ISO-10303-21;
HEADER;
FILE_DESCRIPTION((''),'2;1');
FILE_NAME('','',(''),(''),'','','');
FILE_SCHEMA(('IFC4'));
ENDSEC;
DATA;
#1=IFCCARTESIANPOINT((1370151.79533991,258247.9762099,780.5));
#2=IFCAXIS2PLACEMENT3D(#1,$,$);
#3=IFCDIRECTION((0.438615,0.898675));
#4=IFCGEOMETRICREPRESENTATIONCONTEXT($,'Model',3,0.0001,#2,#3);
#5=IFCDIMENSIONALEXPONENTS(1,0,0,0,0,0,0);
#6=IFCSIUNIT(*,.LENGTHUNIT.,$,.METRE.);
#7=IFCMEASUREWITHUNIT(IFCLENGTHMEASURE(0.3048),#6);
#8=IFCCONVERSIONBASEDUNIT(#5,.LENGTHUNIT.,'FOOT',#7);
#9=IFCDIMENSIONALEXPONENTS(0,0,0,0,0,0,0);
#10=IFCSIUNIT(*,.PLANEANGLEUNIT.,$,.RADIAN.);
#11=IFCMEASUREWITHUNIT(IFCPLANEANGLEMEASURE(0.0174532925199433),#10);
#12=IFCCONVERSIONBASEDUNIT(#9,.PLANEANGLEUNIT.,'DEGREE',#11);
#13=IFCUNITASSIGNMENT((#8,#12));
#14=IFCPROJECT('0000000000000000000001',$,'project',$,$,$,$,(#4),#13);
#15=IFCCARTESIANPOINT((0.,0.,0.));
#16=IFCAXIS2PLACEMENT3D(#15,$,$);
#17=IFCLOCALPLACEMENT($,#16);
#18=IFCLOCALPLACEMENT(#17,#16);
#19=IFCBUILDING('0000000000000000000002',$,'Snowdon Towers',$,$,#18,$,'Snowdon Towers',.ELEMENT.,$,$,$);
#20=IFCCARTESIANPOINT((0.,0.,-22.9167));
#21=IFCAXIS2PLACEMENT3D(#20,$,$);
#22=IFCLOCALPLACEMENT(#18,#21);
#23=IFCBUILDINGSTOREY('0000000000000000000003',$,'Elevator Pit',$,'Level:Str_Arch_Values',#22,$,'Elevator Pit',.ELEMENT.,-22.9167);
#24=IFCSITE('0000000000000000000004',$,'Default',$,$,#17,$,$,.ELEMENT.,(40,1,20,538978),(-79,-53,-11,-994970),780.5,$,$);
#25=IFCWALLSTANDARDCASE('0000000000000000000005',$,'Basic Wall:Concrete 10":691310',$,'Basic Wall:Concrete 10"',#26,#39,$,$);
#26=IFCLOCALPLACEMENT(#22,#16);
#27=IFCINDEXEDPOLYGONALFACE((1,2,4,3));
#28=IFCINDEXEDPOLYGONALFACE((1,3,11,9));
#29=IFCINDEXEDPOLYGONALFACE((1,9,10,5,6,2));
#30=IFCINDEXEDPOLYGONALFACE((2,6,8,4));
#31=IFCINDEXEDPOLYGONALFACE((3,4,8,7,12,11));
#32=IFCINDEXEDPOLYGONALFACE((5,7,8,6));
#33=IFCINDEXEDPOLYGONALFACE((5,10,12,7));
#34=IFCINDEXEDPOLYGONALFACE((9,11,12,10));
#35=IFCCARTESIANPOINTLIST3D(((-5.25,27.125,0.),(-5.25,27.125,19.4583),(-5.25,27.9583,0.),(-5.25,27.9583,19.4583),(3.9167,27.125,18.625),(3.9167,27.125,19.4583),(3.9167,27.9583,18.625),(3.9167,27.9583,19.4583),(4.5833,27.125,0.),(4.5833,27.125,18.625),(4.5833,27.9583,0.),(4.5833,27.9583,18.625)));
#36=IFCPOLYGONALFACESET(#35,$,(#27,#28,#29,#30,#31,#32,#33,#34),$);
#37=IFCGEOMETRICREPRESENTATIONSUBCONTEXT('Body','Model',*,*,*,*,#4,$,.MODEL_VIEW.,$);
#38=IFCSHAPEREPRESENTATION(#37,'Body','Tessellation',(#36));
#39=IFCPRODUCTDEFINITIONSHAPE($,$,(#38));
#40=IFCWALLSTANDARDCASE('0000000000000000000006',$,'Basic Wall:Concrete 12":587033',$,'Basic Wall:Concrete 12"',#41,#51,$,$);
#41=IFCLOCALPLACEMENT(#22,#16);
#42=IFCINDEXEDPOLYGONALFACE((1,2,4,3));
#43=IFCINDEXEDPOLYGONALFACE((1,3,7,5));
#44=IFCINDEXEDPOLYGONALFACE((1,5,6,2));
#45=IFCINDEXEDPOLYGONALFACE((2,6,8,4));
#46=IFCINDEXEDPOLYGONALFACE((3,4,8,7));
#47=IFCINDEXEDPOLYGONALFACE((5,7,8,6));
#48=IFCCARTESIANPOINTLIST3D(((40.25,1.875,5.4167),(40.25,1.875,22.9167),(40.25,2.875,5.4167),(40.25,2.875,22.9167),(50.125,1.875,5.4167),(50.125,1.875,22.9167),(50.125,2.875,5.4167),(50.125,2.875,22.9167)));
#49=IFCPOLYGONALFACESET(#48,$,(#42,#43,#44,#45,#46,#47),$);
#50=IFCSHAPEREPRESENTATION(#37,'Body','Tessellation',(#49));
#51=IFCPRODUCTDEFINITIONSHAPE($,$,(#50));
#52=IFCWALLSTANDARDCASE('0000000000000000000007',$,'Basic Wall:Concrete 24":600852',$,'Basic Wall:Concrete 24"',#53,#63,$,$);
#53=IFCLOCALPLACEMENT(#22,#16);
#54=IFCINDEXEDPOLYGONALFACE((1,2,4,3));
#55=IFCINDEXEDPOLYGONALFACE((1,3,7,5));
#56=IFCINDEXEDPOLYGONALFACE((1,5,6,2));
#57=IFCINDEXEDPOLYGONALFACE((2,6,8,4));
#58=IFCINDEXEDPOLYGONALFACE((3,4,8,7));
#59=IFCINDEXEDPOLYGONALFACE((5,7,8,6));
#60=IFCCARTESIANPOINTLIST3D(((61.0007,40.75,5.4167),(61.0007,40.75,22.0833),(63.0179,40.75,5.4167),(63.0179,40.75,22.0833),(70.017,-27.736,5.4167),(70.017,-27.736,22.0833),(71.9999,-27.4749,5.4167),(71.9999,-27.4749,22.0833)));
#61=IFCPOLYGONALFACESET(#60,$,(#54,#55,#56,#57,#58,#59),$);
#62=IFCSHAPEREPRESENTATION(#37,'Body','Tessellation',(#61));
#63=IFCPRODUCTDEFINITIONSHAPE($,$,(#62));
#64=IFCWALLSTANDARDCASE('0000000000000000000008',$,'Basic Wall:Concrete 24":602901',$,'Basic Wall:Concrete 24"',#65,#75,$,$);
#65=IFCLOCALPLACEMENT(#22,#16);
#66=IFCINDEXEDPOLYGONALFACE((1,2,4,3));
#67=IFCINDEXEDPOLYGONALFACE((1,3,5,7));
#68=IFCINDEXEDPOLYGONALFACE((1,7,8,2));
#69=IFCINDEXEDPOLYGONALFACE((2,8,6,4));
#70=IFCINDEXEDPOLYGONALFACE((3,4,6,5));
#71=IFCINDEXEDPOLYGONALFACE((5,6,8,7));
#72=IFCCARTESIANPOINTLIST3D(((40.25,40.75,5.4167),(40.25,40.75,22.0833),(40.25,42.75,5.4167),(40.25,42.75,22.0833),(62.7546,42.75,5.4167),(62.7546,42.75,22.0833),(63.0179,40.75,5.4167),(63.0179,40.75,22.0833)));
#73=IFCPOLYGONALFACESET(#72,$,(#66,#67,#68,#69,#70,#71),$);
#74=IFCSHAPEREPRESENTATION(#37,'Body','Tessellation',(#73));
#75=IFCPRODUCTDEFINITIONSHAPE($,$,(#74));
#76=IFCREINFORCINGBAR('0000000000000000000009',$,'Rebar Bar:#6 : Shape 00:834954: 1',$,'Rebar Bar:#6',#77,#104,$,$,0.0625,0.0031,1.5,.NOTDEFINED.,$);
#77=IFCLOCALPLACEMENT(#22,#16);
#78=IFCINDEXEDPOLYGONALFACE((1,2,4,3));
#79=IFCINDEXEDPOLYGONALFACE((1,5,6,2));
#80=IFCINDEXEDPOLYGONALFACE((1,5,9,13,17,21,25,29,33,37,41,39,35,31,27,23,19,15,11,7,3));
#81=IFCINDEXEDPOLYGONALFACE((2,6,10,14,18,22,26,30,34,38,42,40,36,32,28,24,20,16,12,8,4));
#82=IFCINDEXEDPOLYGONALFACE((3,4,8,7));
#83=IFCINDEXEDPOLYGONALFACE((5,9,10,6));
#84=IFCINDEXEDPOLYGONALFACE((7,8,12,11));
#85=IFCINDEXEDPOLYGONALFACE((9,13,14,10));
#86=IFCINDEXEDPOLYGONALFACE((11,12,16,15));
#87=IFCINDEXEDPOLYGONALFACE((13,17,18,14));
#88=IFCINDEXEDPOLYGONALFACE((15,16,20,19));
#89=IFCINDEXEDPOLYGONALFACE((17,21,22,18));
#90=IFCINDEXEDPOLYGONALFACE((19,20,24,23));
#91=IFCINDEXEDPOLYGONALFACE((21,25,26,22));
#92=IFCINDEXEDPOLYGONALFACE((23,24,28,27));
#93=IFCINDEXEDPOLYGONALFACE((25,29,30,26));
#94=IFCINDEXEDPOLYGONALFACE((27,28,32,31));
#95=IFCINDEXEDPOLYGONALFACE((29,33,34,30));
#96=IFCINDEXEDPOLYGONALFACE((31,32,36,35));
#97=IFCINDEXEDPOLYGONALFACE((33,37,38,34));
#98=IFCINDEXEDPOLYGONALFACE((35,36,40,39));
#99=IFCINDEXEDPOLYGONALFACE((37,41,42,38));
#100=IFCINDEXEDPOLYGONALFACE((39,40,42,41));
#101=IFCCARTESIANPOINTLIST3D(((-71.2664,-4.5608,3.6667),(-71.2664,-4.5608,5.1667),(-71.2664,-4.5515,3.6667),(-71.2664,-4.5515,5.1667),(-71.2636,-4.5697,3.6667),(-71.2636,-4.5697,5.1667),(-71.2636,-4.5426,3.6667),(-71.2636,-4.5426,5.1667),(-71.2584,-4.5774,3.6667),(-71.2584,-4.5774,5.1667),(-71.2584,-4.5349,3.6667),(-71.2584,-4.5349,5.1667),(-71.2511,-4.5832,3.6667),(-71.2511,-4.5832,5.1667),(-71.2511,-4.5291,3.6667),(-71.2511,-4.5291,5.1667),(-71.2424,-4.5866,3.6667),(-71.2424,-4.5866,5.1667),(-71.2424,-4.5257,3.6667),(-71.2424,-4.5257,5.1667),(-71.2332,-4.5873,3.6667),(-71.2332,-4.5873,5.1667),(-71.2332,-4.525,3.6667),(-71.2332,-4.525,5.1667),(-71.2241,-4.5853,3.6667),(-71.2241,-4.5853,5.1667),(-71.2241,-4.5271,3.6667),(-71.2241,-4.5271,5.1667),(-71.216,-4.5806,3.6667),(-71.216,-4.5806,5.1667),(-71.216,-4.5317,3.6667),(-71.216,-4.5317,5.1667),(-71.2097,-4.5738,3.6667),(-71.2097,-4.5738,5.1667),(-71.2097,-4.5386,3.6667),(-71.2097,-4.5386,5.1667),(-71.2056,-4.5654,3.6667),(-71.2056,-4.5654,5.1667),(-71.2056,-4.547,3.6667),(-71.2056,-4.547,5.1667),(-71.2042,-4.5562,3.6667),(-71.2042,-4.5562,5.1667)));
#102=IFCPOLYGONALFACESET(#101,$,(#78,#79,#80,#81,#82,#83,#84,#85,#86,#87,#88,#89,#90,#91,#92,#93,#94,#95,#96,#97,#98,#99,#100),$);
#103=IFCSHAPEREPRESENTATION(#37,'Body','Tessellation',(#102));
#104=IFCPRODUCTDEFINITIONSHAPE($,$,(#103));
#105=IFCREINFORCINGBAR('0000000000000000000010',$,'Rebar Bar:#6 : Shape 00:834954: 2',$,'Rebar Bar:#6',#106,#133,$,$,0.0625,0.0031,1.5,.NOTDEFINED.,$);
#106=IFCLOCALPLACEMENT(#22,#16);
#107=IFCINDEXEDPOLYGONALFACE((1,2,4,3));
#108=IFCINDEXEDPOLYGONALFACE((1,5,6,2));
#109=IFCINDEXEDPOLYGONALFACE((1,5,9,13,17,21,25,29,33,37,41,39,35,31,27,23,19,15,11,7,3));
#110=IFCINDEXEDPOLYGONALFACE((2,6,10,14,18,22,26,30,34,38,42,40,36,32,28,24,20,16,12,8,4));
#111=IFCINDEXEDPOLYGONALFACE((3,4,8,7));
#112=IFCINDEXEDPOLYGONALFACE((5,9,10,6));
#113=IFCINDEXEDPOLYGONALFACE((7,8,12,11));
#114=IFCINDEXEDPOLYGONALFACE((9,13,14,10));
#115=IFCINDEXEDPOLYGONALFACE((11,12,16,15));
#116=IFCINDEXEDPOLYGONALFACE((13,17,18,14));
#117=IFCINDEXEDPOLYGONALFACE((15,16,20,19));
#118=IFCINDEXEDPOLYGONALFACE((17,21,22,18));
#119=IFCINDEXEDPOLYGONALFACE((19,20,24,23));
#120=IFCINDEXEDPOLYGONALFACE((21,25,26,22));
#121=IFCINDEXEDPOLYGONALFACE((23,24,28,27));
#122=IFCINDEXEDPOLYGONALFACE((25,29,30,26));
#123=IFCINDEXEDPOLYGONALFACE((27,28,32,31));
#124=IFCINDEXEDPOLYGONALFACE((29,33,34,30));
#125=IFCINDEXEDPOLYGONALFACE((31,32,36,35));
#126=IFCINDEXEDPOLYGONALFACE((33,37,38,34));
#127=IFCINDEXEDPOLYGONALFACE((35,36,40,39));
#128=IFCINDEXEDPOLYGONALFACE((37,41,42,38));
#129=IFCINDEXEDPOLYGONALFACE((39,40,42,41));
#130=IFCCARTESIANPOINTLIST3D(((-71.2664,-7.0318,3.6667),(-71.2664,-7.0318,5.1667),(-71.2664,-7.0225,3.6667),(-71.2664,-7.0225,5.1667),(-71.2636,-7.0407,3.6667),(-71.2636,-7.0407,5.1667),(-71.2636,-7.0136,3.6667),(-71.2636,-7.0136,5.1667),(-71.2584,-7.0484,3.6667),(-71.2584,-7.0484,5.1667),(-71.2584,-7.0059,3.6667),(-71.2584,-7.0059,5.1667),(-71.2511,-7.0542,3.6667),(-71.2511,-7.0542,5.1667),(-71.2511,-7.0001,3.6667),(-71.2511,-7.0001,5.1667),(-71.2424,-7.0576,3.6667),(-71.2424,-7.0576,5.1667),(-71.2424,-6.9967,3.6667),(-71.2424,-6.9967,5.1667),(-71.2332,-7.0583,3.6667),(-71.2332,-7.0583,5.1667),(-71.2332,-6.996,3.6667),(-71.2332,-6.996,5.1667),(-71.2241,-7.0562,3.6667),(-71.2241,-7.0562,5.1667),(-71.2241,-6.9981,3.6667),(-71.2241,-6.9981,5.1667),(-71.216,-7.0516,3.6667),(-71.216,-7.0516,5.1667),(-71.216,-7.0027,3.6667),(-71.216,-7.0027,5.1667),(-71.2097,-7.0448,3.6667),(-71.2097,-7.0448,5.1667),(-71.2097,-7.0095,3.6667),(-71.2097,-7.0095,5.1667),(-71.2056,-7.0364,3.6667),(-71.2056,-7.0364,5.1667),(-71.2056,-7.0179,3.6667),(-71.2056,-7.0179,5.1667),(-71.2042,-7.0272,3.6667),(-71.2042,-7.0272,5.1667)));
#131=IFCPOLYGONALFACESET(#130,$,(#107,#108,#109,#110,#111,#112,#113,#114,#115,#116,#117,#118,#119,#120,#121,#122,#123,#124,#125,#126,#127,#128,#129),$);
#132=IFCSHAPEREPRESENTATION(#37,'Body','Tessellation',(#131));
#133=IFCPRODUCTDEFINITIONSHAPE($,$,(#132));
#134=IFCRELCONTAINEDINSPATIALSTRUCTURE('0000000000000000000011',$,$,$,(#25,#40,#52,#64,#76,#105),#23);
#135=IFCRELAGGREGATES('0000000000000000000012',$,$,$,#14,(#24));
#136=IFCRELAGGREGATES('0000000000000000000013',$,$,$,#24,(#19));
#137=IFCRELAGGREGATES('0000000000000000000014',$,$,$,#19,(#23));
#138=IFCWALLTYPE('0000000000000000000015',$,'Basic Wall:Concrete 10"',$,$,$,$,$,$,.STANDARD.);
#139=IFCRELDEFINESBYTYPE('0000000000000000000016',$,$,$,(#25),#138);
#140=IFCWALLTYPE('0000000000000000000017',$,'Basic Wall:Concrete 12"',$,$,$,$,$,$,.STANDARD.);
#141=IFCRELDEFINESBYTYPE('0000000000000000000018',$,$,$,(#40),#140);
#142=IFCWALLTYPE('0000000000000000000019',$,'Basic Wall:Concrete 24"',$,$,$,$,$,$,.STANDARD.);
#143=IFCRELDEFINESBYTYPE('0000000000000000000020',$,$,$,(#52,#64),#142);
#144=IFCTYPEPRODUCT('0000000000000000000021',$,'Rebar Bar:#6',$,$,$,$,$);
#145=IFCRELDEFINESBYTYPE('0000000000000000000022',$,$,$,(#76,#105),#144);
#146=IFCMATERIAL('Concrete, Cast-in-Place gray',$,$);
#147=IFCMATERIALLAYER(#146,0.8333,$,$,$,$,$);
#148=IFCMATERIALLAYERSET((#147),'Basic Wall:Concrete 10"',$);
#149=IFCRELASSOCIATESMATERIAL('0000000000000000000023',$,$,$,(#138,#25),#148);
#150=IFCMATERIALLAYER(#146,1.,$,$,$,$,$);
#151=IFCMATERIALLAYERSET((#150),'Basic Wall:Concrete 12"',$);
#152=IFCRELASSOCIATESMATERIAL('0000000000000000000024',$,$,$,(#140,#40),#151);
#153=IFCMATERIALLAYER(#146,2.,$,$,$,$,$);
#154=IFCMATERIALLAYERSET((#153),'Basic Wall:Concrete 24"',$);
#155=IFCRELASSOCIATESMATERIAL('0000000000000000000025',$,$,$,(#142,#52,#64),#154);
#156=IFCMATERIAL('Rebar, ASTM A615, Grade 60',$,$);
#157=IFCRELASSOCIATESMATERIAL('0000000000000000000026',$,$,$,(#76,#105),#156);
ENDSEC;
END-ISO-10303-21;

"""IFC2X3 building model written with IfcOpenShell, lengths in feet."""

from ifc_helpers import new_model, entity, si_unit, converted_unit, direction, frame, frame_2d, origin, place, context, subcontext, project, spatial, polyline, rectangle, outline, extrude, clip, bounded_halfspace, material, layer, layer_set, layer_usage, type_object, element, save


model = new_model("IFC2X3")

# Units and contexts
model_context = context("Model", 3, precision=0.0001, world=frame((1370151.79533991, 258247.9762099, 780.5)), true_north=direction((0.438615, 0.898675)))
body_context = subcontext(model_context, "Body", "Model", "MODEL_VIEW")
ifc_project = project(units=[converted_unit("LENGTHUNIT", "FOOT", entity("IfcLengthMeasure", 0.3048), si_unit("LENGTHUNIT", "METRE"), dimensions=[1, 0, 0, 0, 0, 0, 0]), converted_unit("PLANEANGLEUNIT", "DEGREE", entity("IfcPlaneAngleMeasure", 0.0174532925199433), si_unit("PLANEANGLEUNIT", "RADIAN"), dimensions=[0, 0, 0, 0, 0, 0, 0])], contexts=[model_context])

# Site, building, storey
site_placement = place(None, origin())
site = spatial("IfcSite", under=ifc_project, at=site_placement, Name="Default", CompositionType="ELEMENT", RefLatitude=(40, 1, 20, 538978), RefLongitude=(-79, -53, -11, -994970), RefElevation=780.5)
building_placement = place(site_placement, origin())
building = spatial("IfcBuilding", under=site, at=building_placement, Name="Snowdon Towers", LongName="Snowdon Towers", CompositionType="ELEMENT")
storey_placement = place(building_placement, frame((0.0, 0.0, -22.9167)))
storey = spatial("IfcBuildingStorey", under=building, at=storey_placement, Name="Elevator Pit", ObjectType="Level:Str_Arch_Values", LongName="Elevator Pit", CompositionType="ELEMENT", Elevation=-22.9167)

# Walls
ifc_material_1 = material(Name="Concrete, Cast-in-Place gray")
ifc_layer_1 = layer(ifc_material_1, 0.8333)
ifc_layer_set_1 = layer_set([ifc_layer_1], Name="Basic Wall:Concrete 10\"")
ifc_layer_usage_1 = layer_usage(ifc_layer_set_1, "AXIS2", "NEGATIVE", 0.4167)
wall_type_1 = type_object("IfcWallType", Name="Basic Wall:Concrete 10\"", PredefinedType="STANDARD", material=ifc_layer_set_1)
wall_1_placement = place(storey_placement, frame((4.5833, 27.5417, 0.0), z_axis=(0.0, 0.0, 1.0), x_axis=(-1.0, 0.0, 0.0)))
element("IfcWallStandardCase", 1, at=wall_1_placement, inside=storey, type_object=wall_type_1, material=ifc_layer_usage_1, Name="Basic Wall:Concrete 10\":691310", ObjectType="Basic Wall:Concrete 10\"", context=body_context, shape_type="Clipping", body=[
    clip(clip(extrude(rectangle(XDim=9.8333, YDim=0.8333, at=frame_2d((4.9167, 0.0), x_axis=(-1.0, 0.0))), origin(), (0.0, 0.0, 1.0), 19.4583), bounded_halfspace(frame((0.6667, -0.4167, 18.625), z_axis=(0.0, 0.0, -1.0), x_axis=(1.0, 0.0, 0.0)), True, frame((0.6667, -0.4167, 18.625), z_axis=(0.0, 0.0, -1.0), x_axis=(1.0, 0.0, 0.0)), polyline([(0.0, 0.0), (-0.6667, 0.0), (-0.6667, -0.8333), (0.0, -0.8333), (0.0, 0.0)]))), bounded_halfspace(frame((0.6667, 0.4167, 18.625), z_axis=(1.0, 0.0, 0.0), x_axis=(0.0, 0.0, 1.0)), True, frame((0.6667, 0.4167, 18.625), z_axis=(1.0, 0.0, 0.0), x_axis=(0.0, 0.0, 1.0)), polyline([(0.0, 0.0), (0.8333, 0.0), (0.8333, 0.8333), (0.0, 0.8333), (0.0, 0.0)]))),
])
ifc_layer_2 = layer(ifc_material_1, 1.0)
ifc_layer_set_2 = layer_set([ifc_layer_2], Name="Basic Wall:Concrete 12\"")
ifc_layer_usage_2 = layer_usage(ifc_layer_set_2, "AXIS2", "NEGATIVE", 0.5)
wall_type_2 = type_object("IfcWallType", Name="Basic Wall:Concrete 12\"", PredefinedType="STANDARD", material=ifc_layer_set_2)
wall_2_placement = place(storey_placement, frame((50.125, 2.375, 5.4167), z_axis=(0.0, 0.0, 1.0), x_axis=(-1.0, 0.0, 0.0)))
element("IfcWallStandardCase", 2, at=wall_2_placement, inside=storey, type_object=wall_type_2, material=ifc_layer_usage_2, Name="Basic Wall:Concrete 12\":587033", ObjectType="Basic Wall:Concrete 12\"", context=body_context, shape_type="SweptSolid", body=[
    extrude(rectangle(XDim=9.875, YDim=1.0, at=frame_2d((4.9375, 0.0), x_axis=(-1.0, 0.0))), origin(), (0.0, 0.0, 1.0), 17.5),
])
ifc_layer_3 = layer(ifc_material_1, 2.0)
ifc_layer_set_3 = layer_set([ifc_layer_3], Name="Basic Wall:Concrete 24\"")
ifc_layer_usage_3 = layer_usage(ifc_layer_set_3, "AXIS2", "NEGATIVE", 1.0)
wall_type_3 = type_object("IfcWallType", Name="Basic Wall:Concrete 24\"", PredefinedType="STANDARD", material=ifc_layer_set_3)
wall_3_placement = place(storey_placement, frame((61.9921, 40.8805, 5.4167), z_axis=(0.0, 0.0, 1.0), x_axis=(0.130526, -0.991445, 0.0)))
element("IfcWallStandardCase", 3, at=wall_3_placement, inside=storey, type_object=wall_type_3, material=ifc_layer_usage_3, Name="Basic Wall:Concrete 24\":600852", ObjectType="Basic Wall:Concrete 24\"", context=body_context, shape_type="Clipping", body=[
    clip(extrude(outline(polyline([(69.0769, -1.0), (69.0769, 1.0), (0.2633, 1.0), (0.0, -1.0), (67.0769, -1.0), (69.0769, -1.0)])), origin(), (0.0, 0.0, 1.0), 16.6667), bounded_halfspace(frame((0.0, -1.0, 16.6667), z_axis=(0.0, 0.0, -1.0), x_axis=(-0.130526, -0.991445, 0.0)), True, frame((0.0, -1.0, 16.6667), z_axis=(0.0, 0.0, -1.0), x_axis=(-0.130526, -0.991445, 0.0)), polyline([(0.0, 0.0), (-2.0173, 0.0), (-10.9992, -68.2249), (-9.0163, -68.486), (-8.7553, -66.5031), (0.0, 0.0)]))),
])
ifc_layer_usage_4 = layer_usage(ifc_layer_set_3, "AXIS2", "NEGATIVE", 1.0)
wall_4_placement = place(storey_placement, frame((40.25, 41.75, 5.4167)))
element("IfcWallStandardCase", 4, at=wall_4_placement, inside=storey, type_object=wall_type_3, material=ifc_layer_usage_4, Name="Basic Wall:Concrete 24\":602901", ObjectType="Basic Wall:Concrete 24\"", context=body_context, shape_type="Clipping", body=[
    clip(extrude(outline(polyline([(22.7679, -1.0), (22.5046, 1.0), (0.0, 1.0), (0.0, -1.0), (20.7507, -1.0), (22.7679, -1.0)])), origin(), (0.0, 0.0, 1.0), 16.6667), bounded_halfspace(frame((0.0, -1.0, 16.6667), z_axis=(0.0, 0.0, -1.0), x_axis=(-1.0, 0.0, 0.0)), True, frame((0.0, -1.0, 16.6667), z_axis=(0.0, 0.0, -1.0), x_axis=(-1.0, 0.0, 0.0)), polyline([(0.0, 0.0), (0.0, 2.0), (-22.5046, 2.0), (-22.7679, 0.0), (-20.7507, 0.0), (-2.0, 0.0), (0.0, 0.0)]))),
])

# Reinforcing bars
ifc_material_2 = material(Name="Rebar, ASTM A615, Grade 60")
type_product = type_object("IfcTypeProduct", Name="Rebar Bar:#6")
reinforcing_bar_1_placement = place(storey_placement, origin())
element("IfcReinforcingBar", 5, at=reinforcing_bar_1_placement, inside=storey, type_object=type_product, material=ifc_material_2, Name="Rebar Bar:#6 : Shape 00:834954: 1", ObjectType="Rebar Bar:#6", BarLength=1.5, BarRole="NOTDEFINED", CrossSectionArea=0.0031, NominalDiameter=0.0625, context=body_context, shape_type="AdvancedSweptSolid", body=[
    entity("IfcSweptDiskSolid", entity("IfcCompositeCurve", [entity("IfcCompositeCurveSegment", "CONTINUOUS", True, entity("IfcPolyline", [entity("IfcCartesianPoint", [-71.2355, -4.5562, 3.6667]), entity("IfcCartesianPoint", [-71.2355, -4.5562, 5.1667])]))], False), 0.0312, None, 0.0, 1.0),
])
reinforcing_bar_2_placement = place(storey_placement, origin())
element("IfcReinforcingBar", 6, at=reinforcing_bar_2_placement, inside=storey, type_object=type_product, material=ifc_material_2, Name="Rebar Bar:#6 : Shape 00:834954: 2", ObjectType="Rebar Bar:#6", BarLength=1.5, BarRole="NOTDEFINED", CrossSectionArea=0.0031, NominalDiameter=0.0625, context=body_context, shape_type="AdvancedSweptSolid", body=[
    entity("IfcSweptDiskSolid", entity("IfcCompositeCurve", [entity("IfcCompositeCurveSegment", "CONTINUOUS", True, entity("IfcPolyline", [entity("IfcCartesianPoint", [-71.2355, -7.0272, 3.6667]), entity("IfcCartesianPoint", [-71.2355, -7.0272, 5.1667])]))], False), 0.0312, None, 0.0, 1.0),
])

save(model, "model.ifc")
